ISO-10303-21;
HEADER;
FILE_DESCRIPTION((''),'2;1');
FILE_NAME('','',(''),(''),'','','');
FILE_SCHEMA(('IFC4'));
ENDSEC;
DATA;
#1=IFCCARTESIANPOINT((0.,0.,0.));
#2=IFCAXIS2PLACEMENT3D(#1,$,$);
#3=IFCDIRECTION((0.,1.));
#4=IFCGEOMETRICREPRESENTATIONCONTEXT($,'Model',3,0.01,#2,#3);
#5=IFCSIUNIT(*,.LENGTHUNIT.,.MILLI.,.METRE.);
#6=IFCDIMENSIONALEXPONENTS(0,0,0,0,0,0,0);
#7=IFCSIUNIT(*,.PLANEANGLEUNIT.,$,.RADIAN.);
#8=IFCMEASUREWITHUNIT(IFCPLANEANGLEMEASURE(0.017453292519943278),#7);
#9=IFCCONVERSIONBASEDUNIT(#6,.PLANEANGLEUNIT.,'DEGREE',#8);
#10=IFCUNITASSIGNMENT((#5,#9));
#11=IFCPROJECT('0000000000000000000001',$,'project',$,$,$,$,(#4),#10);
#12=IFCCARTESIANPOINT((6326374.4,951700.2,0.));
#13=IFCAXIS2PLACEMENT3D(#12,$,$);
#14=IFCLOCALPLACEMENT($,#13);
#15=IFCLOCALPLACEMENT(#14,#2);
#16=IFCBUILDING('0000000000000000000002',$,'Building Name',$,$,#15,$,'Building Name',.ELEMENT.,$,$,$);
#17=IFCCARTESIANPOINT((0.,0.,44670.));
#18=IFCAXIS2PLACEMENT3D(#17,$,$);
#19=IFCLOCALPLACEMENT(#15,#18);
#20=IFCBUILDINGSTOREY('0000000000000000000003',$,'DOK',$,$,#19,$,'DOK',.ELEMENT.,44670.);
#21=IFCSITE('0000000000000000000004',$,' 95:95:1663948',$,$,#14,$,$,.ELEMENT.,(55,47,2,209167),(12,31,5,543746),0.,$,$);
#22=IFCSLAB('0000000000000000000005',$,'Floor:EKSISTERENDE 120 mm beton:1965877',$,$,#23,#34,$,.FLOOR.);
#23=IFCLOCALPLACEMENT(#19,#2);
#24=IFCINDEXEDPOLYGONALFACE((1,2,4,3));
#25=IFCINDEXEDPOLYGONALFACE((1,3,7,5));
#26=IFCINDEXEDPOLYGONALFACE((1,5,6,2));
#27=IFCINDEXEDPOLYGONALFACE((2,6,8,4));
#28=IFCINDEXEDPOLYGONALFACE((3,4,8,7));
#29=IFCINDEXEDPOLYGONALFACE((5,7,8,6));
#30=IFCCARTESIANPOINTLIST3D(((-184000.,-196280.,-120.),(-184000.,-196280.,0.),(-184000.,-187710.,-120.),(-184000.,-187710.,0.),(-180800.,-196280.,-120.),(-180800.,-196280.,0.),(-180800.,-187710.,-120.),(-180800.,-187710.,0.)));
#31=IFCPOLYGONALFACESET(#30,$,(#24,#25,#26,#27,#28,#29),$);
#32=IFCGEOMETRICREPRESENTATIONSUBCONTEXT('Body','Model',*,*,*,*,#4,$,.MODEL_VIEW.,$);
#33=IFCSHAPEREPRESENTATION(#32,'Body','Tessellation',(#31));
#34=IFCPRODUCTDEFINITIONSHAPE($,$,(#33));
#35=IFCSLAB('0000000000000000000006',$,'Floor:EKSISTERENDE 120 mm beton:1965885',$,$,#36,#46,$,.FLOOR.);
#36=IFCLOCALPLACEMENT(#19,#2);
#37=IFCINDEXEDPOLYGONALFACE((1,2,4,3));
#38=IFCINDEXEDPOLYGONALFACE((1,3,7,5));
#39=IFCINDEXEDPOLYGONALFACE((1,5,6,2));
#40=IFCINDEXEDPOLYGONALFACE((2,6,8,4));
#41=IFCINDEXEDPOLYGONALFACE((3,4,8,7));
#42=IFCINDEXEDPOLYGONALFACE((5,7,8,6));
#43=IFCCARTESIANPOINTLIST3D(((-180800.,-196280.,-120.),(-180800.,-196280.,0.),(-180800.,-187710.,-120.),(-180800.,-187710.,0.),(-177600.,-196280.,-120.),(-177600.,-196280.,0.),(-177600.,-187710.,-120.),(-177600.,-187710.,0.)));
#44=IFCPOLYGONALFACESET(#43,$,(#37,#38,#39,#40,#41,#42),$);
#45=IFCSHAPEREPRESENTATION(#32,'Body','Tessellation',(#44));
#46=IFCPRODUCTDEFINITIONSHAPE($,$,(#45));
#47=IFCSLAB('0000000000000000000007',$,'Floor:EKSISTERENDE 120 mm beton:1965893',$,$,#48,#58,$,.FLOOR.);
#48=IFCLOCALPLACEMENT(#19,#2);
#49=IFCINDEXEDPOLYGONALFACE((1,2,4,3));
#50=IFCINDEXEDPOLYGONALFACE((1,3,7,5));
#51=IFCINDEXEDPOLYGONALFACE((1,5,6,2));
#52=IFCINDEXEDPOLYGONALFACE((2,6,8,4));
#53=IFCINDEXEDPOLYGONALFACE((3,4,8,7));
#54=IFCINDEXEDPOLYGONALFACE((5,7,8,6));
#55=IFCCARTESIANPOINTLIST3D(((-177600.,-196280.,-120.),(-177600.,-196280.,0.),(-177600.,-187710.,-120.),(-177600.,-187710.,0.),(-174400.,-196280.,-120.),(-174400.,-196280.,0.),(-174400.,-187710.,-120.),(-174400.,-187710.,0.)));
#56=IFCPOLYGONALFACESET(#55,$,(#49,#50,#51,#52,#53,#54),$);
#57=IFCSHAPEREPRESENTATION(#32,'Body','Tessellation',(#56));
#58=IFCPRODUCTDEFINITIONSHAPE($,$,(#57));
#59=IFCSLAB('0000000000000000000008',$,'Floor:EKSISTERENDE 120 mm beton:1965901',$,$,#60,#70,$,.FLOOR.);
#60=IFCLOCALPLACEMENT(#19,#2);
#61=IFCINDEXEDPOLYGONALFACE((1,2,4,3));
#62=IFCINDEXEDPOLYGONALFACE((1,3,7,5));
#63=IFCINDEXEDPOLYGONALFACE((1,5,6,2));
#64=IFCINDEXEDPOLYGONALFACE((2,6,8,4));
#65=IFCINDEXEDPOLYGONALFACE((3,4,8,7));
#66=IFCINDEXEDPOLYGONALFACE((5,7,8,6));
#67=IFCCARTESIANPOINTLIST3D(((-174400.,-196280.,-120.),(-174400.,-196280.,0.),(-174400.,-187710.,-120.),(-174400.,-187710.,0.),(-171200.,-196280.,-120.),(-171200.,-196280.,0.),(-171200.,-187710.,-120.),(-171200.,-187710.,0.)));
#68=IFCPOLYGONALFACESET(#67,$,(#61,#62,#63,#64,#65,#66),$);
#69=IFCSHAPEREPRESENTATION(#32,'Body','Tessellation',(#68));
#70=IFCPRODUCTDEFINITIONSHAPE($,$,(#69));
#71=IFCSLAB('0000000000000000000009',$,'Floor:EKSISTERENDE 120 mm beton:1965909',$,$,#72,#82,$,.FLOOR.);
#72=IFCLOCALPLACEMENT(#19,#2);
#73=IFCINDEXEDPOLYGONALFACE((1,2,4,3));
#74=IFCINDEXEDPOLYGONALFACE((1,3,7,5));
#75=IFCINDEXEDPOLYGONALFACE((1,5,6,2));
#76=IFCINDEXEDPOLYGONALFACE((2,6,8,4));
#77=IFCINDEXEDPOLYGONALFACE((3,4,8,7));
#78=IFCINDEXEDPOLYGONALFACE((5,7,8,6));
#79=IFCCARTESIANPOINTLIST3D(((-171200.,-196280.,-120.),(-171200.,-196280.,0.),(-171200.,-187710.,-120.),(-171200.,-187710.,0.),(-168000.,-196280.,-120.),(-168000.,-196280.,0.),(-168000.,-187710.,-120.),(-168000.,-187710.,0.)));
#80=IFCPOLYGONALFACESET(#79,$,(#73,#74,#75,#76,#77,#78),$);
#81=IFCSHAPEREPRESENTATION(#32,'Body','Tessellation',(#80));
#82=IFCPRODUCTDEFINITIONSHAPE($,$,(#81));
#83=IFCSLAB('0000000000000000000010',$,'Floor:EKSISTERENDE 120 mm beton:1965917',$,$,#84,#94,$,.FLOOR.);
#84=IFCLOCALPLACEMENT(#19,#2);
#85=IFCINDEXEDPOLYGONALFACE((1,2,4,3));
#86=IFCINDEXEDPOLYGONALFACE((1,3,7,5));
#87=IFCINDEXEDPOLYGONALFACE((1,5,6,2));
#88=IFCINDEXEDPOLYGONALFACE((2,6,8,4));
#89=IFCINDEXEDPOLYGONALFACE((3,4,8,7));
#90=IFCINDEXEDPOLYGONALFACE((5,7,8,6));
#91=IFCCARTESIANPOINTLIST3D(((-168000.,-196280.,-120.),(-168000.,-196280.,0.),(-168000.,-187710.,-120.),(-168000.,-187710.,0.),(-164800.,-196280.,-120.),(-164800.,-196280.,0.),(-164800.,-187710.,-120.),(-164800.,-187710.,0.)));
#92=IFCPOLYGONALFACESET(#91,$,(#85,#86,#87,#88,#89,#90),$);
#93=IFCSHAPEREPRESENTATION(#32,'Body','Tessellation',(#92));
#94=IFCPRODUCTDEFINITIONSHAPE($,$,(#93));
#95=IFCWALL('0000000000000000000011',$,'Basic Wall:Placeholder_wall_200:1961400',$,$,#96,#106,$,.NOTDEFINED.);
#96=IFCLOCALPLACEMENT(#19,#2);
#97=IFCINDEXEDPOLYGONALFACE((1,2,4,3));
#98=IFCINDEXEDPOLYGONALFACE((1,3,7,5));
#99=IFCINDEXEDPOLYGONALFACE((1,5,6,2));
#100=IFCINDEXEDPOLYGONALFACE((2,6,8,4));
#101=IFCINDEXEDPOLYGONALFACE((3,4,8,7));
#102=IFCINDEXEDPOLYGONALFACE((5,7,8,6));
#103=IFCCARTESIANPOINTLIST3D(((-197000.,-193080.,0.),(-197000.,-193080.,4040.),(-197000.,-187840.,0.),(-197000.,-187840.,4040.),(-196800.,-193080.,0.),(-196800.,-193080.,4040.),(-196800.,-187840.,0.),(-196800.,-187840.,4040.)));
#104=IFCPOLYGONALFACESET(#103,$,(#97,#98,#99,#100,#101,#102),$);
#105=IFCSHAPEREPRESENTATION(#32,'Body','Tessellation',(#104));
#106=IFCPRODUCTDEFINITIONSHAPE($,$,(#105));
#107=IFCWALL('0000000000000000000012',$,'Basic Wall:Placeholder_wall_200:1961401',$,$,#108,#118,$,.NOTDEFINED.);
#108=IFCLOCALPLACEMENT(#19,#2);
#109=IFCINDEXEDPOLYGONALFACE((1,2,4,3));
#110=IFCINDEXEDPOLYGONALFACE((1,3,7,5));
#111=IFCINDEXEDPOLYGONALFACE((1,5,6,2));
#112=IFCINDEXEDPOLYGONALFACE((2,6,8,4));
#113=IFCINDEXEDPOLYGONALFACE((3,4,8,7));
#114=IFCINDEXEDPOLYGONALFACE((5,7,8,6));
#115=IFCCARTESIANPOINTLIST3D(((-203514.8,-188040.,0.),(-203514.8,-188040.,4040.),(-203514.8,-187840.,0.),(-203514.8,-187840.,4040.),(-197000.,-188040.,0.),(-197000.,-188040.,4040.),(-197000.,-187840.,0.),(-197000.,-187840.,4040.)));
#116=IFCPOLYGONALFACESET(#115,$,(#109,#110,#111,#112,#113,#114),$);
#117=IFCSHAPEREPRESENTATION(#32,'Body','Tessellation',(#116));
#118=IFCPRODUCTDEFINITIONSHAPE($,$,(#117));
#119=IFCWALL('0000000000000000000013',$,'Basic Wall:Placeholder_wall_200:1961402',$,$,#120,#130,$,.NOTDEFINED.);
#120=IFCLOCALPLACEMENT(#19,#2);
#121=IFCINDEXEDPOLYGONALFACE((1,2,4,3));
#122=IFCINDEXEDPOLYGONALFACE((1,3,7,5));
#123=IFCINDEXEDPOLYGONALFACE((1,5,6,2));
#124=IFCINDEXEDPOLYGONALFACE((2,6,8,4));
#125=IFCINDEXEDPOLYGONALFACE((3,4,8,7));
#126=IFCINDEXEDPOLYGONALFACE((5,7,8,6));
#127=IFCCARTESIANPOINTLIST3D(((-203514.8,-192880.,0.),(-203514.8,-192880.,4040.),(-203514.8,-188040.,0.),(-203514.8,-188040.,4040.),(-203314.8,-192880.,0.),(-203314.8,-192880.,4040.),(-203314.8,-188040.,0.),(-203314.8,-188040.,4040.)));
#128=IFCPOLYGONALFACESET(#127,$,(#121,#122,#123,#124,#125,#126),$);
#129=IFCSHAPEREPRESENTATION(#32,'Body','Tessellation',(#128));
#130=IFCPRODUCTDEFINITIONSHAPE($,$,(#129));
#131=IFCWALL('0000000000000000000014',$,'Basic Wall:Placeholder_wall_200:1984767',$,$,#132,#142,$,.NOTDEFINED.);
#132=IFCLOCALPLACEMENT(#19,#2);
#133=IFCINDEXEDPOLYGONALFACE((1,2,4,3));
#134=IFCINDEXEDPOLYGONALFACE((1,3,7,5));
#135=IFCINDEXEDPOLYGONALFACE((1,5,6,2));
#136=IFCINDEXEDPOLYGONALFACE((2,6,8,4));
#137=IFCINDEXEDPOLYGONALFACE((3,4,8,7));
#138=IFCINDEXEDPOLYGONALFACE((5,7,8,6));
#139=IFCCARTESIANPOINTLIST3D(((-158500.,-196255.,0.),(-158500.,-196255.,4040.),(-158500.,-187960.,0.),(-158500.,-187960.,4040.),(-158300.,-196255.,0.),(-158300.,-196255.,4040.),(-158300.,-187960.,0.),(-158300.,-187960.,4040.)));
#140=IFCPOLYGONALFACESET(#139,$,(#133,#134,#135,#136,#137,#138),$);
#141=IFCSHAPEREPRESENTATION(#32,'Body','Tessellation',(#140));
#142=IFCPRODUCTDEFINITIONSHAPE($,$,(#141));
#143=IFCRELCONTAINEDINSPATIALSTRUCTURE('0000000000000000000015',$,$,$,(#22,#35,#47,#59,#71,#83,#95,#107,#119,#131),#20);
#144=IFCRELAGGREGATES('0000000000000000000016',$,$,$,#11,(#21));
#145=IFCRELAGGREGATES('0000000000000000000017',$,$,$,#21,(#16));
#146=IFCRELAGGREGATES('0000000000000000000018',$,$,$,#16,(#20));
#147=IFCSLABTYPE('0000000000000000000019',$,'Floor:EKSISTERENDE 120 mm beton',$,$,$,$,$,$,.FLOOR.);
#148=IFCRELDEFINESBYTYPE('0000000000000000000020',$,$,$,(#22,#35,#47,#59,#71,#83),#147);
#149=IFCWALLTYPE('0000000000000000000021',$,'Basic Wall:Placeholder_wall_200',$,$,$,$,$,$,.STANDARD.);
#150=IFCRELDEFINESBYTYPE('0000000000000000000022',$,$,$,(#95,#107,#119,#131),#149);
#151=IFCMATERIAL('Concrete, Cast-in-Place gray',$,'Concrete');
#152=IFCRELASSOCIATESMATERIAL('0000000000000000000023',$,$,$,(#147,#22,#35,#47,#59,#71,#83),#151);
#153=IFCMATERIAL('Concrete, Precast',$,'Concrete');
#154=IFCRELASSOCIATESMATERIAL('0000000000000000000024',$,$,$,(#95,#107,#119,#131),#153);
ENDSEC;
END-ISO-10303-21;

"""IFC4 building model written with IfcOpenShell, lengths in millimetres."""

from ifc_helpers import new_model, entity, si_unit, converted_unit, direction, frame, origin, place, context, subcontext, project, spatial, indexed_curve, outline, extrude, material, type_object, element, save


model = new_model("IFC4")

# Units and contexts
model_context = context("Model", 3, precision=0.01, world=origin(), true_north=direction((0.0, 1.0)))
body_context = subcontext(model_context, "Body", "Model", "MODEL_VIEW")
ifc_project = project(units=[si_unit("LENGTHUNIT", "METRE", prefix="MILLI"), converted_unit("PLANEANGLEUNIT", "DEGREE", entity("IfcPlaneAngleMeasure", 0.017453292519943278), si_unit("PLANEANGLEUNIT", "RADIAN"), dimensions=[0, 0, 0, 0, 0, 0, 0])], contexts=[model_context])

# Site, building, storey
site_placement = place(None, frame((6326374.4, 951700.2, 0.0)))
site = spatial("IfcSite", under=ifc_project, at=site_placement, Name=" 95:95:1663948", CompositionType="ELEMENT", RefLatitude=(55, 47, 2, 209167), RefLongitude=(12, 31, 5, 543746), RefElevation=0.0)
building_placement = place(site_placement, origin())
building = spatial("IfcBuilding", under=site, at=building_placement, Name="Building Name", LongName="Building Name", CompositionType="ELEMENT")
storey_placement = place(building_placement, frame((0.0, 0.0, 44670.0)))
storey = spatial("IfcBuildingStorey", under=building, at=storey_placement, Name="DOK", LongName="DOK", CompositionType="ELEMENT", Elevation=44670.0)

# Shared definitions
ifc_material_1 = material(Name="Concrete, Precast", Category="Concrete")

# Slabs
ifc_material_2 = material(Name="Concrete, Cast-in-Place gray", Category="Concrete")
slab_type_1 = type_object("IfcSlabType", Name="Floor:EKSISTERENDE 120 mm beton", PredefinedType="FLOOR", material=ifc_material_2)
slab_1_placement = place(storey_placement, origin())
element("IfcSlab", 1, at=slab_1_placement, inside=storey, type_object=slab_type_1, material=ifc_material_2, Name="Floor:EKSISTERENDE 120 mm beton:1965877", PredefinedType="FLOOR", context=body_context, shape_type="SweptSolid", body=[
    extrude(outline(indexed_curve([(-4285.0, -1600.0), (4285.0, -1600.0), (4285.0, 1600.0), (-4285.0, 1600.0), (-4285.0, -1600.0)], self_intersect=False)), frame((-182400.0, -191995.0, 0.0), z_axis=(0.0, 0.0, -1.0), x_axis=(0.0, 1.0, 0.0)), (0.0, 0.0, 1.0), 120.0),
])
slab_2_placement = place(storey_placement, origin())
element("IfcSlab", 2, at=slab_2_placement, inside=storey, type_object=slab_type_1, material=ifc_material_2, Name="Floor:EKSISTERENDE 120 mm beton:1965885", PredefinedType="FLOOR", context=body_context, shape_type="SweptSolid", body=[
    extrude(outline(indexed_curve([(-4285.0, -1600.0), (4285.0, -1600.0), (4285.0, 1600.0), (-4285.0, 1600.0), (-4285.0, -1600.0)], self_intersect=False)), frame((-179200.0, -191995.0, 0.0), z_axis=(0.0, 0.0, -1.0), x_axis=(0.0, 1.0, 0.0)), (0.0, 0.0, 1.0), 120.0),
])
slab_3_placement = place(storey_placement, origin())
element("IfcSlab", 3, at=slab_3_placement, inside=storey, type_object=slab_type_1, material=ifc_material_2, Name="Floor:EKSISTERENDE 120 mm beton:1965893", PredefinedType="FLOOR", context=body_context, shape_type="SweptSolid", body=[
    extrude(outline(indexed_curve([(-4285.0, -1600.0), (4285.0, -1600.0), (4285.0, 1600.0), (-4285.0, 1600.0), (-4285.0, -1600.0)], self_intersect=False)), frame((-176000.0, -191995.0, 0.0), z_axis=(0.0, 0.0, -1.0), x_axis=(0.0, 1.0, 0.0)), (0.0, 0.0, 1.0), 120.0),
])
slab_4_placement = place(storey_placement, origin())
element("IfcSlab", 4, at=slab_4_placement, inside=storey, type_object=slab_type_1, material=ifc_material_2, Name="Floor:EKSISTERENDE 120 mm beton:1965901", PredefinedType="FLOOR", context=body_context, shape_type="SweptSolid", body=[
    extrude(outline(indexed_curve([(-4285.0, -1600.0), (4285.0, -1600.0), (4285.0, 1600.0), (-4285.0, 1600.0), (-4285.0, -1600.0)], self_intersect=False)), frame((-172800.0, -191995.0, 0.0), z_axis=(0.0, 0.0, -1.0), x_axis=(0.0, 1.0, 0.0)), (0.0, 0.0, 1.0), 120.0),
])
slab_5_placement = place(storey_placement, origin())
element("IfcSlab", 5, at=slab_5_placement, inside=storey, type_object=slab_type_1, material=ifc_material_2, Name="Floor:EKSISTERENDE 120 mm beton:1965909", PredefinedType="FLOOR", context=body_context, shape_type="SweptSolid", body=[
    extrude(outline(indexed_curve([(-4285.0, -1600.0), (4285.0, -1600.0), (4285.0, 1600.0), (-4285.0, 1600.0), (-4285.0, -1600.0)], self_intersect=False)), frame((-169600.0, -191995.0, 0.0), z_axis=(0.0, 0.0, -1.0), x_axis=(0.0, 1.0, 0.0)), (0.0, 0.0, 1.0), 120.0),
])
slab_6_placement = place(storey_placement, origin())
element("IfcSlab", 6, at=slab_6_placement, inside=storey, type_object=slab_type_1, material=ifc_material_2, Name="Floor:EKSISTERENDE 120 mm beton:1965917", PredefinedType="FLOOR", context=body_context, shape_type="SweptSolid", body=[
    extrude(outline(indexed_curve([(-4285.0, -1600.0), (4285.0, -1600.0), (4285.0, 1600.0), (-4285.0, 1600.0), (-4285.0, -1600.0)], self_intersect=False)), frame((-166400.0, -191995.0, 0.0), z_axis=(0.0, 0.0, -1.0), x_axis=(0.0, 1.0, 0.0)), (0.0, 0.0, 1.0), 120.0),
])

# Walls
wall_type = type_object("IfcWallType", Name="Basic Wall:Placeholder_wall_200", PredefinedType="STANDARD")
wall_1_placement = place(storey_placement, frame((-196900.0, -193080.0, 0.0), z_axis=(0.0, 0.0, 1.0), x_axis=(0.0, 1.0, 0.0)))
element("IfcWall", 7, at=wall_1_placement, inside=storey, type_object=wall_type, material=ifc_material_1, Name="Basic Wall:Placeholder_wall_200:1961400", PredefinedType="NOTDEFINED", context=body_context, shape_type="SweptSolid", body=[
    extrude(outline(indexed_curve([(5240.0, 100.0), (0.0, 100.0), (0.0, -100.0), (5240.0, -100.0), (5240.0, 100.0)], self_intersect=False)), origin(), (0.0, 0.0, 1.0), 4040.0),
])
wall_2_placement = place(storey_placement, frame((-197000.0, -187940.0, 0.0), z_axis=(0.0, 0.0, 1.0), x_axis=(-1.0, 0.0, 0.0)))
element("IfcWall", 8, at=wall_2_placement, inside=storey, type_object=wall_type, material=ifc_material_1, Name="Basic Wall:Placeholder_wall_200:1961401", PredefinedType="NOTDEFINED", context=body_context, shape_type="SweptSolid", body=[
    extrude(outline(indexed_curve([(6514.8, 100.0), (0.0, 100.0), (0.0, -100.0), (6514.8, -100.0), (6514.8, 100.0)], self_intersect=False)), origin(), (0.0, 0.0, 1.0), 4040.0),
])
wall_3_placement = place(storey_placement, frame((-203414.8, -188040.0, 0.0), z_axis=(0.0, 0.0, 1.0), x_axis=(0.0, -1.0, 0.0)))
element("IfcWall", 9, at=wall_3_placement, inside=storey, type_object=wall_type, material=ifc_material_1, Name="Basic Wall:Placeholder_wall_200:1961402", PredefinedType="NOTDEFINED", context=body_context, shape_type="SweptSolid", body=[
    extrude(outline(indexed_curve([(4840.0, 100.0), (0.0, 100.0), (0.0, -100.0), (4840.0, -100.0), (4840.0, 100.0)], self_intersect=False)), origin(), (0.0, 0.0, 1.0), 4040.0),
])
wall_4_placement = place(storey_placement, frame((-158400.0, -187960.0, 0.0), z_axis=(0.0, 0.0, 1.0), x_axis=(0.0, -1.0, 0.0)))
element("IfcWall", 10, at=wall_4_placement, inside=storey, type_object=wall_type, material=ifc_material_1, Name="Basic Wall:Placeholder_wall_200:1984767", PredefinedType="NOTDEFINED", context=body_context, shape_type="SweptSolid", body=[
    extrude(outline(indexed_curve([(8295.0, 100.0), (0.0, 100.0), (0.0, -100.0), (8295.0, -100.0), (8295.0, 100.0)], self_intersect=False)), origin(), (0.0, 0.0, 1.0), 4040.0),
])

save(model, "model.ifc")
